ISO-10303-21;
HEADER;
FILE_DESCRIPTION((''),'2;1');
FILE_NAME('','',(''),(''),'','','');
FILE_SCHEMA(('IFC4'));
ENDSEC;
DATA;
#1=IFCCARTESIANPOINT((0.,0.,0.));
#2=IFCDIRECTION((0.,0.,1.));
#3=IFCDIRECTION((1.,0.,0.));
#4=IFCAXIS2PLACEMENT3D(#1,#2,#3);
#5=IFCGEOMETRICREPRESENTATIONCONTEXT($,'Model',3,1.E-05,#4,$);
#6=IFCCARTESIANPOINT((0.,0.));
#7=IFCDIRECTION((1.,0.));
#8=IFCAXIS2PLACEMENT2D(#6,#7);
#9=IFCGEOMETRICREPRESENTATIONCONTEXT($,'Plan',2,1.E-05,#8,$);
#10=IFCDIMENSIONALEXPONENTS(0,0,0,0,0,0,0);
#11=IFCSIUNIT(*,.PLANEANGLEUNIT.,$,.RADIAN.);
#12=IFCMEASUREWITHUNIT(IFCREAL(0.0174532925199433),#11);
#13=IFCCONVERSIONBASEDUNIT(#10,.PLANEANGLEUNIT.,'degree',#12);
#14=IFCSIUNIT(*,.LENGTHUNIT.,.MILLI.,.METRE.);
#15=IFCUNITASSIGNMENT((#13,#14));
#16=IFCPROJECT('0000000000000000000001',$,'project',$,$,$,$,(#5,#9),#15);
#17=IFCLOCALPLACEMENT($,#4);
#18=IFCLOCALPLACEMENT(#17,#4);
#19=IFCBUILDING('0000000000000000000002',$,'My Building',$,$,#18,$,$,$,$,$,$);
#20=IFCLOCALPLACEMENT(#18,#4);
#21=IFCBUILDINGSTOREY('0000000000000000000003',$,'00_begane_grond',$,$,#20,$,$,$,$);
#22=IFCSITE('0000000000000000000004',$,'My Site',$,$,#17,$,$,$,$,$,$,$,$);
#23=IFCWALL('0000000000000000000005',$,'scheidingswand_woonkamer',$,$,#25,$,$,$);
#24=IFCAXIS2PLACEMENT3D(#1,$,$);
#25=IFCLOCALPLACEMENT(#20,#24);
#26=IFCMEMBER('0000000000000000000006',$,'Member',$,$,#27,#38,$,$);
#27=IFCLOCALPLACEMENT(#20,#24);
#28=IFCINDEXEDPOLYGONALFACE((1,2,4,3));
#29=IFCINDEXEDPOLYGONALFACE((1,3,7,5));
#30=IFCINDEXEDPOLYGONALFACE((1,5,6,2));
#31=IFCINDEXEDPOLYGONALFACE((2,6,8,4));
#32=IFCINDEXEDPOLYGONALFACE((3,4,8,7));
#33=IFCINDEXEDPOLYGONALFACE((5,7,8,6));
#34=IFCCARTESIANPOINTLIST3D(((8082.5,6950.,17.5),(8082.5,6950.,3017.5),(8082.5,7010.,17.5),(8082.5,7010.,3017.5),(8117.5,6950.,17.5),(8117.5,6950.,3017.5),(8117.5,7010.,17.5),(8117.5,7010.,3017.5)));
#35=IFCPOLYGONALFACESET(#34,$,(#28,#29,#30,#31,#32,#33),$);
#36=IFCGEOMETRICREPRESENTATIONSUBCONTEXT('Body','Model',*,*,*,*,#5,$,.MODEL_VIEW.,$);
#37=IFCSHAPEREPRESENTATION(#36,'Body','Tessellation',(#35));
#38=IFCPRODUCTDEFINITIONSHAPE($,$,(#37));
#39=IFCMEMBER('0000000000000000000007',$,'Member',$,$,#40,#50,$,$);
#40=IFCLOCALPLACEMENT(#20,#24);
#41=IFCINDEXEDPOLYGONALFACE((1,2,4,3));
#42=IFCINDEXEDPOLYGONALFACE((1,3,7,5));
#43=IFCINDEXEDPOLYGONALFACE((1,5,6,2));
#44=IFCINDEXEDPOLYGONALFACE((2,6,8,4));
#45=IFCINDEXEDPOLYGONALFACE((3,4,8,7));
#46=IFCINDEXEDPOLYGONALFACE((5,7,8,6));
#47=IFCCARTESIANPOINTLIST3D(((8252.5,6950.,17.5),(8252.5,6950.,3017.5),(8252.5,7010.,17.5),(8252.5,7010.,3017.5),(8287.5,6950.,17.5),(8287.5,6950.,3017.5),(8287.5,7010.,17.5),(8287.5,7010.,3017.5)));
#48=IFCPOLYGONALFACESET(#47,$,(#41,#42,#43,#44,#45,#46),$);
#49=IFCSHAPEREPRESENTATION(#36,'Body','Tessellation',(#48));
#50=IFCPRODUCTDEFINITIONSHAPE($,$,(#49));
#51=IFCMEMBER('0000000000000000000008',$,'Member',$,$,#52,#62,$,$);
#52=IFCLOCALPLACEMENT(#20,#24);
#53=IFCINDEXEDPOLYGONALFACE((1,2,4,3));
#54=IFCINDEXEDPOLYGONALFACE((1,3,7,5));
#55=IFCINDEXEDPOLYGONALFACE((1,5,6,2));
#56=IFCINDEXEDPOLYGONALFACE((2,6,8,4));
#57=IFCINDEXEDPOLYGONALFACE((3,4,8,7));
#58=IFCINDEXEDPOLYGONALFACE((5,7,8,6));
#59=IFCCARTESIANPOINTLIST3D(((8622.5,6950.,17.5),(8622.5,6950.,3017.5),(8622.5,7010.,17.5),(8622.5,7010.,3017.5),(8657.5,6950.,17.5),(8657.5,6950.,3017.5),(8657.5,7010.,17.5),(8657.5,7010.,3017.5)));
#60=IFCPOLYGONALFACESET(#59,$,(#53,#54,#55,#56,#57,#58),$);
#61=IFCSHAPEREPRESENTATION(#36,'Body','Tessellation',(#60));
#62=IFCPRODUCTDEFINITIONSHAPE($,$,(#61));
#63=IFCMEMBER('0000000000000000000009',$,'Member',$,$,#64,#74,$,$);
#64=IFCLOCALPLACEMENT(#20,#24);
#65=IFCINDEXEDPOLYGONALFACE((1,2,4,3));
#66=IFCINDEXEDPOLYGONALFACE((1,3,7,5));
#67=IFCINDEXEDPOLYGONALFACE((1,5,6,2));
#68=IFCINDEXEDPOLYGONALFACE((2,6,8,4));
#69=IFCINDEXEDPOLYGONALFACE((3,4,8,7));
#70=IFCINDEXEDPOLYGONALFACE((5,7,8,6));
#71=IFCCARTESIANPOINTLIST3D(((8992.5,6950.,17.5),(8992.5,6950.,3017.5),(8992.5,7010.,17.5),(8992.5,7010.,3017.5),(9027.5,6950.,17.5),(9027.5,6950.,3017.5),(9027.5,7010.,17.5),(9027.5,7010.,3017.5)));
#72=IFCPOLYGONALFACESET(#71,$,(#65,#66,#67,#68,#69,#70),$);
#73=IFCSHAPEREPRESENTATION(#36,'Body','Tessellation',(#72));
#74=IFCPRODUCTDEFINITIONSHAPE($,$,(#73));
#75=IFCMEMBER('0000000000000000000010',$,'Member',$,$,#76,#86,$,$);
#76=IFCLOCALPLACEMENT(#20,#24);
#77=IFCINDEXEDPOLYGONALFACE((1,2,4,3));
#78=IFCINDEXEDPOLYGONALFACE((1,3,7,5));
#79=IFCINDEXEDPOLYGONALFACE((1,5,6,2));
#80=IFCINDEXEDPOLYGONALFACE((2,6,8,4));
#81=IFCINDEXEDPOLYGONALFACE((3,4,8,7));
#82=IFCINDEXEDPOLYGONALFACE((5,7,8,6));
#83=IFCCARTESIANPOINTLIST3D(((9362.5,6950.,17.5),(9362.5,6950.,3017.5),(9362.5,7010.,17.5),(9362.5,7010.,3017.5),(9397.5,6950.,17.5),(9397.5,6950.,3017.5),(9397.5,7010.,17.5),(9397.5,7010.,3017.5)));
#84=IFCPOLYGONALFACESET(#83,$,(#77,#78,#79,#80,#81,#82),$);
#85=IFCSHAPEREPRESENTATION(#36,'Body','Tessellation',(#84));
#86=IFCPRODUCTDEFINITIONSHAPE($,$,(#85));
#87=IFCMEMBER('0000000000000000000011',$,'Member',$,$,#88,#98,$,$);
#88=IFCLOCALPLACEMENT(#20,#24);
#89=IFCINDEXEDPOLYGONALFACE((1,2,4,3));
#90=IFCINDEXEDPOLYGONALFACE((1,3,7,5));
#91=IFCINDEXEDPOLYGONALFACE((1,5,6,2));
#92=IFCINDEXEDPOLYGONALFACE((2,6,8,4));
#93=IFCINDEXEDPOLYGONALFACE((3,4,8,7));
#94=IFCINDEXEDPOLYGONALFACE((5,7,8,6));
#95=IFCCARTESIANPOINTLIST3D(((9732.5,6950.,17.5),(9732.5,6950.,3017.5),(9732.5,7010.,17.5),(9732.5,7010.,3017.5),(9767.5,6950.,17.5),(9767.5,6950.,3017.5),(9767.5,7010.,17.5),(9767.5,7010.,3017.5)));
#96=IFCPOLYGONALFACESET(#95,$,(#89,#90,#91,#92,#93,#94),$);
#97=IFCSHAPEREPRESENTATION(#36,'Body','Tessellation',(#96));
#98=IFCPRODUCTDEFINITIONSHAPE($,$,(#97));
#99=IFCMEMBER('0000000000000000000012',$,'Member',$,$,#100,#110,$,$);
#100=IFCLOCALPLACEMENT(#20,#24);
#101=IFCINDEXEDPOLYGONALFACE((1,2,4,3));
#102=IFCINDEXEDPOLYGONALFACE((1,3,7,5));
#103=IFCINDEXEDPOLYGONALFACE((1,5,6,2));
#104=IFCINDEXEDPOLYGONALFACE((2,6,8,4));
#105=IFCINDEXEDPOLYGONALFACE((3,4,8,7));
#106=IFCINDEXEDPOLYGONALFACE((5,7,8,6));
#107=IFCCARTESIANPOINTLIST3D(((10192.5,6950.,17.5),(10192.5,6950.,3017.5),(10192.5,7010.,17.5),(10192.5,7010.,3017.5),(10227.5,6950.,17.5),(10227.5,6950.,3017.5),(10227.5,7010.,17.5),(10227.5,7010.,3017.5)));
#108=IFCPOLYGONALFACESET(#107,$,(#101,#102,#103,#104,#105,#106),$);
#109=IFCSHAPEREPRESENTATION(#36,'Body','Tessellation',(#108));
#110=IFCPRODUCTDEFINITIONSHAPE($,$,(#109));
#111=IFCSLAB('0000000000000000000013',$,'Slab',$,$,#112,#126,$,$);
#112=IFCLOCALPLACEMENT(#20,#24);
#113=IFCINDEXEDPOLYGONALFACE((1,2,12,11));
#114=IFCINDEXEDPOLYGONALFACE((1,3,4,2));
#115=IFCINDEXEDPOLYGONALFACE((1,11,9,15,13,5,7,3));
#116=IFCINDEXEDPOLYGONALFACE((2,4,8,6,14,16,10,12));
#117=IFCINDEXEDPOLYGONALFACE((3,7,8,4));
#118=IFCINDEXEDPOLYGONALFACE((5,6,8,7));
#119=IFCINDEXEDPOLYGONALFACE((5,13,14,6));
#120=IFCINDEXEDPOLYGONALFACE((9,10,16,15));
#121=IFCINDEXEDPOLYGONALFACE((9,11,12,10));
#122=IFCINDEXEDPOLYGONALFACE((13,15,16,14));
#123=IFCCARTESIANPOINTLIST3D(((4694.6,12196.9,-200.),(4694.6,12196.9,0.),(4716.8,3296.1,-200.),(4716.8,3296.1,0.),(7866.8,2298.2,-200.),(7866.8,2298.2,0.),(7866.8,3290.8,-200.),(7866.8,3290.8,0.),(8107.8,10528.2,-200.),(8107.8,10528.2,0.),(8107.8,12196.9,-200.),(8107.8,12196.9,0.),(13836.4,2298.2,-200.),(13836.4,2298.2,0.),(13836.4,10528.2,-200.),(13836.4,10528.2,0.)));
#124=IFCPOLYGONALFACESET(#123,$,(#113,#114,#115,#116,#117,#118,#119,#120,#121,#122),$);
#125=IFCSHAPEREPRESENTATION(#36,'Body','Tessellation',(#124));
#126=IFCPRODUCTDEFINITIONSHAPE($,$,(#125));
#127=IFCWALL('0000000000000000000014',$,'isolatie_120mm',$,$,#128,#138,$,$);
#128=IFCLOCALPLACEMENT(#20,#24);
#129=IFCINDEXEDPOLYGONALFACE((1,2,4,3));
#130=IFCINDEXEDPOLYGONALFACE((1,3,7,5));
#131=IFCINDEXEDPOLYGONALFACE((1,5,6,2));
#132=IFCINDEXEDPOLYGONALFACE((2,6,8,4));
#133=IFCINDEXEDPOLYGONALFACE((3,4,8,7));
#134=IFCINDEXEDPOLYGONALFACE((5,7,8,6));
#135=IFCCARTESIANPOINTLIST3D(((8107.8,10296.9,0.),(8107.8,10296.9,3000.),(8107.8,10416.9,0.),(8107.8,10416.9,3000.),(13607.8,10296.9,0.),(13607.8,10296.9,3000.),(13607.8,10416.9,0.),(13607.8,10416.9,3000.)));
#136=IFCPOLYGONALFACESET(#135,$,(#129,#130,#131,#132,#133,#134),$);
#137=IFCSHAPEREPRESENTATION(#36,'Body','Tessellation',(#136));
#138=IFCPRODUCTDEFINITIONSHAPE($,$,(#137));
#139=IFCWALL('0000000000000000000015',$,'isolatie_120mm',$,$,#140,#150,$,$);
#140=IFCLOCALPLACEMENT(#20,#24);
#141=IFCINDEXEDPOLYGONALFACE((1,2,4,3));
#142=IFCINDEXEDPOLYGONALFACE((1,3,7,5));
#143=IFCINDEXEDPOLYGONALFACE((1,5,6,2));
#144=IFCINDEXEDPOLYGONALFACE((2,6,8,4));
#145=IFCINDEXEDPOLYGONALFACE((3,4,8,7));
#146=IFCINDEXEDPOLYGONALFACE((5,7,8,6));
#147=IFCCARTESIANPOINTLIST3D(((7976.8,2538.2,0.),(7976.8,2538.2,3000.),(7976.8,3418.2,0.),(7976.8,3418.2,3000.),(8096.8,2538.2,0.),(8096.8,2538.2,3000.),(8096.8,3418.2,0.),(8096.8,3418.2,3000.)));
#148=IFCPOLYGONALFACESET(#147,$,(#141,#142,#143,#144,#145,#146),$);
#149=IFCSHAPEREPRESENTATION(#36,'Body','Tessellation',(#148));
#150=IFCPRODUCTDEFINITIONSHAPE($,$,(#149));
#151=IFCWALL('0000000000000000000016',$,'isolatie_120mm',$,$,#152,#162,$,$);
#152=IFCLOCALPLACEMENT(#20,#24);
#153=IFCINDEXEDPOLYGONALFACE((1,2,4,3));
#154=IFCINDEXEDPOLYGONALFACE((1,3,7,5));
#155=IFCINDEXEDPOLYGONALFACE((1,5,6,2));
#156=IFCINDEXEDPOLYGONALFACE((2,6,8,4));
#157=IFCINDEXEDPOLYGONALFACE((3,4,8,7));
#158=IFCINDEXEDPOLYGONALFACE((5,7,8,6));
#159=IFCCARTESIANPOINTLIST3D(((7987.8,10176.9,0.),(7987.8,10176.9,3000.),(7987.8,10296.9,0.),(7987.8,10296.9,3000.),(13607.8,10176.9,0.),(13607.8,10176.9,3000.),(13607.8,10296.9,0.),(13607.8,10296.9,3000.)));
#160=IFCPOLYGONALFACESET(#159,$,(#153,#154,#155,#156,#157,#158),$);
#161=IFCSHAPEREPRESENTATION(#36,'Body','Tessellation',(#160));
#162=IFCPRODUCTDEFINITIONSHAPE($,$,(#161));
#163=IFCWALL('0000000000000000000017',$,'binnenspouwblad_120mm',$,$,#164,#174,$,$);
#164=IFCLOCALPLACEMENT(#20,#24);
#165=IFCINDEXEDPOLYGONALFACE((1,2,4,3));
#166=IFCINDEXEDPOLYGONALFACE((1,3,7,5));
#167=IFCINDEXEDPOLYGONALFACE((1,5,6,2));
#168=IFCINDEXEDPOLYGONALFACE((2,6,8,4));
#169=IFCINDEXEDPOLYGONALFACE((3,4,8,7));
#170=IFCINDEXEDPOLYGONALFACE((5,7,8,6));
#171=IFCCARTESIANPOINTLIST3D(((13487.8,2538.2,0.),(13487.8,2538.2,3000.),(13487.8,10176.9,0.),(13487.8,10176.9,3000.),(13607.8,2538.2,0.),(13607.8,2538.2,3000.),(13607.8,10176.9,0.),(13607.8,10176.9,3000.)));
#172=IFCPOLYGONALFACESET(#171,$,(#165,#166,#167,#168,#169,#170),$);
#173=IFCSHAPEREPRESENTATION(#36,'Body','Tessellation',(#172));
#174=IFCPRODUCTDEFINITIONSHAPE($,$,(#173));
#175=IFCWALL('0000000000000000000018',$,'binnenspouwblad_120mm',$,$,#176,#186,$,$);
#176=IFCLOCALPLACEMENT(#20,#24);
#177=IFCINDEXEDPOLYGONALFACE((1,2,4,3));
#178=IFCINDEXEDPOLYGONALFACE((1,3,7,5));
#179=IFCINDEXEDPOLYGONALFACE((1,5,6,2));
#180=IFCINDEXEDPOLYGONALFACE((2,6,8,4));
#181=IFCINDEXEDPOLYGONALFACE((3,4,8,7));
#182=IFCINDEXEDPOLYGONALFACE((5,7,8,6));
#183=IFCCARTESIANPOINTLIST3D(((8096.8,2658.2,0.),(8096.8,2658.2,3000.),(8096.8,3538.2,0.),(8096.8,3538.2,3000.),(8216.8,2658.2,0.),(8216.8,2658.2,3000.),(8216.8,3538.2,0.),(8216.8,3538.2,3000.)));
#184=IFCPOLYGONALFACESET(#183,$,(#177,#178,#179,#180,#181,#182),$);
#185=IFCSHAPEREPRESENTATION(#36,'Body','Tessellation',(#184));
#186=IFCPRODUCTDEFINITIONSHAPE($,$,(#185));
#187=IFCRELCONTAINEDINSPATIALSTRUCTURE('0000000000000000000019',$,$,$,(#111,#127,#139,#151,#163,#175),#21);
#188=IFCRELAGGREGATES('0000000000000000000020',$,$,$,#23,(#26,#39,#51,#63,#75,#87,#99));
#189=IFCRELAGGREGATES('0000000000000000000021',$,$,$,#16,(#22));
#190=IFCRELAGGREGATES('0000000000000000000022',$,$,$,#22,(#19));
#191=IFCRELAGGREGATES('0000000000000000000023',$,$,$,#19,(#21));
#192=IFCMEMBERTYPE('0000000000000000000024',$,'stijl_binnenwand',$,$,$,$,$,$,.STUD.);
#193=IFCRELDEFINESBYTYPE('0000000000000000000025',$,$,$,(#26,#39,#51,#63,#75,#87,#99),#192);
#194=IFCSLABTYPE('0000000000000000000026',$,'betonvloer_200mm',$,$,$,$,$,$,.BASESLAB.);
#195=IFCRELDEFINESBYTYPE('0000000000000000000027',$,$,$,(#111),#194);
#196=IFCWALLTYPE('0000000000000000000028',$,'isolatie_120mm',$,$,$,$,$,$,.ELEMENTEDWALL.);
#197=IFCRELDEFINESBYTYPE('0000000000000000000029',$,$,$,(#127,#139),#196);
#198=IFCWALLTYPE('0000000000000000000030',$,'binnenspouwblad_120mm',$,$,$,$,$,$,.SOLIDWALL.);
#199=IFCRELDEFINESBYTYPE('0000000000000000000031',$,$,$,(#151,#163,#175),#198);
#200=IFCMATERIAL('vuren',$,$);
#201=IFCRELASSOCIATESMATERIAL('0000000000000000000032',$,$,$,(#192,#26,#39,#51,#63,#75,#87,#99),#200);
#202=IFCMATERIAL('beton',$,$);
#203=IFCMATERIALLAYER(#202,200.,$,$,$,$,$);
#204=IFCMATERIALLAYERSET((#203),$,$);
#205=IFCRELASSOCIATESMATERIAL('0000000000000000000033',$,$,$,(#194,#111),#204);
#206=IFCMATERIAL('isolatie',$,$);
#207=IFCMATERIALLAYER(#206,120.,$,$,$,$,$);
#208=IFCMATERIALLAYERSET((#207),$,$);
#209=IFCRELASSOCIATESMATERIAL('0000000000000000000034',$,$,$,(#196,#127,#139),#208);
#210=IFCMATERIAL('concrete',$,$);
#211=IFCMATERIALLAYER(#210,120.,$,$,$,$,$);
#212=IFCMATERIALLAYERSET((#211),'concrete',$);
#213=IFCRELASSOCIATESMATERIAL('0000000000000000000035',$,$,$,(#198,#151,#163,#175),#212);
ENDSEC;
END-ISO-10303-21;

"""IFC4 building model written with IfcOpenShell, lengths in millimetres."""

from ifc_helpers import new_model, entity, si_unit, converted_unit, frame, origin_with_axes, origin_2d_with_axis, place, context, subcontext, project, spatial, line, indexed_curve, rectangle, outline, extrude, material, layer, layer_set, layer_usage, material_profile, profile_set, profile_usage, type_object, element, aggregate, save


model = new_model("IFC4")

# Units and contexts
model_context = context("Model", 3, precision=1e-05, world=origin_with_axes())
plan_context = context("Plan", 2, precision=1e-05, world=origin_2d_with_axis())
body_context = subcontext(model_context, "Body", "Model", "MODEL_VIEW")
ifc_project = project(units=[converted_unit("PLANEANGLEUNIT", "degree", entity("IfcReal", 0.0174532925199433), si_unit("PLANEANGLEUNIT", "RADIAN"), dimensions=[0, 0, 0, 0, 0, 0, 0]), si_unit("LENGTHUNIT", "METRE", prefix="MILLI")], contexts=[model_context, plan_context])

# Site, building, storey
site_placement = place(None, origin_with_axes())
site = spatial("IfcSite", under=ifc_project, at=site_placement, Name="My Site")
building_placement = place(site_placement, origin_with_axes())
building = spatial("IfcBuilding", under=site, at=building_placement, Name="My Building")
storey_placement = place(building_placement, origin_with_axes())
storey = spatial("IfcBuildingStorey", under=building, at=storey_placement, Name="00_begane_grond")

# Shared definitions
ifc_material_1 = material(Name="vuren")

# Wall, members
wall_1_placement = place(storey_placement, origin_with_axes())
wall_2_placement = place(wall_1_placement, origin_with_axes())
wall_2 = element("IfcWall", 1, at=wall_2_placement, Name="scheidingswand_woonkamer")
ifc_material_profile_1 = material_profile(ifc_material_1, rectangle(XDim=35.0, YDim=60.0))
ifc_profile_set_1 = profile_set([ifc_material_profile_1])
ifc_profile_usage_1 = profile_usage(ifc_profile_set_1, cardinal=5)
member_type_1 = type_object("IfcMemberType", Name="stijl_binnenwand", PredefinedType="STUD", material=ifc_profile_set_1)
member_1_placement = place(wall_2_placement, frame((8100.0, 6980.0, 17.5), z_axis=(0.0, 0.0, 1.0), x_axis=(-1.0, 0.0, 0.0)))
member_1 = element("IfcMember", 2, at=member_1_placement, type_object=member_type_1, material=ifc_profile_usage_1, Name="Member", context=body_context, shape_type="SweptSolid", body=[
    extrude(rectangle(XDim=35.0, YDim=60.0), origin_with_axes(), (0.0, 0.0, 1.0), 3000.0),
])
ifc_profile_usage_2 = profile_usage(ifc_profile_set_1, cardinal=5)
member_2_placement = place(wall_2_placement, frame((8270.0, 6980.0, 17.5), z_axis=(0.0, 0.0, 1.0), x_axis=(-1.0, 0.0, 0.0)))
member_2 = element("IfcMember", 3, at=member_2_placement, type_object=member_type_1, material=ifc_profile_usage_2, Name="Member", context=body_context, shape_type="SweptSolid", body=[
    extrude(rectangle(XDim=35.0, YDim=60.0), origin_with_axes(), (0.0, 0.0, 1.0), 3000.0),
])
ifc_profile_usage_3 = profile_usage(ifc_profile_set_1, cardinal=5)
member_3_placement = place(wall_2_placement, frame((8640.0, 6980.0, 17.5), z_axis=(0.0, 0.0, 1.0), x_axis=(-1.0, 0.0, 0.0)))
member_3 = element("IfcMember", 4, at=member_3_placement, type_object=member_type_1, material=ifc_profile_usage_3, Name="Member", context=body_context, shape_type="SweptSolid", body=[
    extrude(rectangle(XDim=35.0, YDim=60.0), origin_with_axes(), (0.0, 0.0, 1.0), 3000.0),
])
ifc_profile_usage_4 = profile_usage(ifc_profile_set_1, cardinal=5)
member_4_placement = place(wall_2_placement, frame((9010.0, 6980.0, 17.5), z_axis=(0.0, 0.0, 1.0), x_axis=(-1.0, 0.0, 0.0)))
member_4 = element("IfcMember", 5, at=member_4_placement, type_object=member_type_1, material=ifc_profile_usage_4, Name="Member", context=body_context, shape_type="SweptSolid", body=[
    extrude(rectangle(XDim=35.0, YDim=60.0), origin_with_axes(), (0.0, 0.0, 1.0), 3000.0),
])
ifc_profile_usage_5 = profile_usage(ifc_profile_set_1, cardinal=5)
member_5_placement = place(wall_2_placement, frame((9380.0, 6980.0, 17.5), z_axis=(0.0, 0.0, 1.0), x_axis=(-1.0, 0.0, 0.0)))
member_5 = element("IfcMember", 6, at=member_5_placement, type_object=member_type_1, material=ifc_profile_usage_5, Name="Member", context=body_context, shape_type="SweptSolid", body=[
    extrude(rectangle(XDim=35.0, YDim=60.0), origin_with_axes(), (0.0, 0.0, 1.0), 3000.0),
])
ifc_profile_usage_6 = profile_usage(ifc_profile_set_1, cardinal=5)
member_6_placement = place(wall_2_placement, frame((9750.0, 6980.0, 17.5), z_axis=(0.0, 0.0, 1.0), x_axis=(-1.0, 0.0, 0.0)))
member_6 = element("IfcMember", 7, at=member_6_placement, type_object=member_type_1, material=ifc_profile_usage_6, Name="Member", context=body_context, shape_type="SweptSolid", body=[
    extrude(rectangle(XDim=35.0, YDim=60.0), origin_with_axes(), (0.0, 0.0, 1.0), 3000.0),
])
ifc_profile_usage_7 = profile_usage(ifc_profile_set_1, cardinal=5)
member_7_placement = place(wall_2_placement, frame((10210.0, 6980.0, 17.5), z_axis=(0.0, 0.0, 1.0), x_axis=(-1.0, 0.0, 0.0)))
member_7 = element("IfcMember", 8, at=member_7_placement, type_object=member_type_1, material=ifc_profile_usage_7, Name="Member", context=body_context, shape_type="SweptSolid", body=[
    extrude(rectangle(XDim=35.0, YDim=60.0), origin_with_axes(), (0.0, 0.0, 1.0), 3000.0),
])

# Slab
ifc_material_2 = material(Name="beton")
ifc_layer_1 = layer(ifc_material_2, 200.0)
ifc_layer_set_1 = layer_set([ifc_layer_1])
ifc_layer_usage_1 = layer_usage(ifc_layer_set_1, "AXIS3", "POSITIVE", 0.0)
slab_type = type_object("IfcSlabType", Name="betonvloer_200mm", PredefinedType="BASESLAB", material=ifc_layer_set_1)
slab_placement = place(storey_placement, frame((7866.8, 2298.2, -200.0), z_axis=(0.0, 0.0, 1.0), x_axis=(1.0, 0.0, 0.0)))
element("IfcSlab", 9, at=slab_placement, inside=storey, type_object=slab_type, material=ifc_layer_usage_1, Name="Slab", context=body_context, shape_type="SweptSolid", body=[
    extrude(outline(indexed_curve([(241.0, 9898.8), (0.0, 0.0), (5969.7, 0.0), (241.0, 8230.0), (0.0, 992.6), (-3150.0, 997.9), (-3172.1, 9898.8), (5969.7, 8230.0)], segments=[line(5, 2), line(2, 3), line(3, 8), line(8, 4), line(4, 1), line(1, 7), line(7, 6), line(6, 5)], self_intersect=False)), None, (0.0, 0.0, 1.0), 200.0),
])

# Walls
ifc_material_3 = material(Name="isolatie")
ifc_layer_2 = layer(ifc_material_3, 120.0)
ifc_layer_set_2 = layer_set([ifc_layer_2])
ifc_layer_usage_2 = layer_usage(ifc_layer_set_2, "AXIS2", "POSITIVE", 0.0)
wall_type_1 = type_object("IfcWallType", Name="isolatie_120mm", PredefinedType="ELEMENTEDWALL", material=ifc_layer_set_2)
wall_3_placement = place(storey_placement, frame((8107.8, 10296.9, 0.0), z_axis=(0.0, 0.0, 1.0), x_axis=(1.0, -0.000001, 0.0)))
element("IfcWall", 10, at=wall_3_placement, inside=storey, type_object=wall_type_1, material=ifc_layer_usage_2, Name="isolatie_120mm", context=body_context, shape_type="SweptSolid", body=[
    extrude(outline(indexed_curve([(0.0, 0.0), (0.0, 120.0), (5500.0, 120.0), (5500.0, 0.0), (0.0, 0.0)], self_intersect=False)), origin_with_axes(), (0.0, 0.0, 1.0), 3000.0),
])
ifc_layer_usage_3 = layer_usage(ifc_layer_set_2, "AXIS2", "POSITIVE", 0.0)
wall_4_placement = place(storey_placement, frame((7976.8, 3418.2, 0.0), z_axis=(0.0, 0.0, 1.0), x_axis=(0.0, -1.0, 0.0)))
element("IfcWall", 11, at=wall_4_placement, inside=storey, type_object=wall_type_1, material=ifc_layer_usage_3, Name="isolatie_120mm", context=body_context, shape_type="SweptSolid", body=[
    extrude(outline(indexed_curve([(0.0, 0.0), (0.0, 120.0), (880.0, 120.0), (880.0, 0.0), (0.0, 0.0)], self_intersect=False)), origin_with_axes(), (0.0, 0.0, 1.0), 3000.0),
])
ifc_material_4 = material(Name="concrete")
ifc_layer_3 = layer(ifc_material_4, 120.0)
ifc_layer_set_3 = layer_set([ifc_layer_3], Name="concrete")
ifc_layer_usage_4 = layer_usage(ifc_layer_set_3, "AXIS2", "POSITIVE", 0.0)
wall_type_2 = type_object("IfcWallType", Name="binnenspouwblad_120mm", PredefinedType="SOLIDWALL", material=ifc_layer_set_3)
wall_5_placement = place(storey_placement, frame((13607.8, 10296.9, 0.0), z_axis=(0.0, 0.0, 1.0), x_axis=(-1.0, 0.000001, 0.0)))
element("IfcWall", 12, at=wall_5_placement, inside=storey, type_object=wall_type_2, material=ifc_layer_usage_4, Name="isolatie_120mm", context=body_context, shape_type="SweptSolid", body=[
    extrude(outline(indexed_curve([(0.0, 0.0), (0.0, 120.0), (5620.0, 120.0), (5620.0, 0.0), (0.0, 0.0)], self_intersect=False)), origin_with_axes(), (0.0, 0.0, 1.0), 3000.0),
])
ifc_layer_usage_5 = layer_usage(ifc_layer_set_3, "AXIS2", "POSITIVE", 0.0)
wall_6_placement = place(storey_placement, frame((13607.8, 2538.2, 0.0), z_axis=(0.0, 0.0, 1.0), x_axis=(0.000001, 1.0, 0.0)))
element("IfcWall", 13, at=wall_6_placement, inside=storey, type_object=wall_type_2, material=ifc_layer_usage_5, Name="binnenspouwblad_120mm", context=body_context, shape_type="SweptSolid", body=[
    extrude(outline(indexed_curve([(0.0, 0.0), (0.0, 120.0), (7638.7, 120.0), (7638.7, 0.0), (0.0, 0.0)], self_intersect=False)), origin_with_axes(), (0.0, 0.0, 1.0), 3000.0),
])
ifc_layer_usage_6 = layer_usage(ifc_layer_set_3, "AXIS2", "POSITIVE", 0.0)
wall_7_placement = place(storey_placement, frame((8096.8, 3538.2, 0.0), z_axis=(0.0, 0.0, 1.0), x_axis=(-0.000001, -1.0, 0.0)))
element("IfcWall", 14, at=wall_7_placement, inside=storey, type_object=wall_type_2, material=ifc_layer_usage_6, Name="binnenspouwblad_120mm", context=body_context, shape_type="SweptSolid", body=[
    extrude(outline(indexed_curve([(0.0, 0.0), (0.0, 120.0), (880.0, 120.0), (880.0, 0.0), (0.0, 0.0)], self_intersect=False)), origin_with_axes(), (0.0, 0.0, 1.0), 3000.0),
])

aggregate(wall_2, [member_1, member_2, member_3, member_4, member_5, member_6, member_7])

save(model, "model.ifc")
